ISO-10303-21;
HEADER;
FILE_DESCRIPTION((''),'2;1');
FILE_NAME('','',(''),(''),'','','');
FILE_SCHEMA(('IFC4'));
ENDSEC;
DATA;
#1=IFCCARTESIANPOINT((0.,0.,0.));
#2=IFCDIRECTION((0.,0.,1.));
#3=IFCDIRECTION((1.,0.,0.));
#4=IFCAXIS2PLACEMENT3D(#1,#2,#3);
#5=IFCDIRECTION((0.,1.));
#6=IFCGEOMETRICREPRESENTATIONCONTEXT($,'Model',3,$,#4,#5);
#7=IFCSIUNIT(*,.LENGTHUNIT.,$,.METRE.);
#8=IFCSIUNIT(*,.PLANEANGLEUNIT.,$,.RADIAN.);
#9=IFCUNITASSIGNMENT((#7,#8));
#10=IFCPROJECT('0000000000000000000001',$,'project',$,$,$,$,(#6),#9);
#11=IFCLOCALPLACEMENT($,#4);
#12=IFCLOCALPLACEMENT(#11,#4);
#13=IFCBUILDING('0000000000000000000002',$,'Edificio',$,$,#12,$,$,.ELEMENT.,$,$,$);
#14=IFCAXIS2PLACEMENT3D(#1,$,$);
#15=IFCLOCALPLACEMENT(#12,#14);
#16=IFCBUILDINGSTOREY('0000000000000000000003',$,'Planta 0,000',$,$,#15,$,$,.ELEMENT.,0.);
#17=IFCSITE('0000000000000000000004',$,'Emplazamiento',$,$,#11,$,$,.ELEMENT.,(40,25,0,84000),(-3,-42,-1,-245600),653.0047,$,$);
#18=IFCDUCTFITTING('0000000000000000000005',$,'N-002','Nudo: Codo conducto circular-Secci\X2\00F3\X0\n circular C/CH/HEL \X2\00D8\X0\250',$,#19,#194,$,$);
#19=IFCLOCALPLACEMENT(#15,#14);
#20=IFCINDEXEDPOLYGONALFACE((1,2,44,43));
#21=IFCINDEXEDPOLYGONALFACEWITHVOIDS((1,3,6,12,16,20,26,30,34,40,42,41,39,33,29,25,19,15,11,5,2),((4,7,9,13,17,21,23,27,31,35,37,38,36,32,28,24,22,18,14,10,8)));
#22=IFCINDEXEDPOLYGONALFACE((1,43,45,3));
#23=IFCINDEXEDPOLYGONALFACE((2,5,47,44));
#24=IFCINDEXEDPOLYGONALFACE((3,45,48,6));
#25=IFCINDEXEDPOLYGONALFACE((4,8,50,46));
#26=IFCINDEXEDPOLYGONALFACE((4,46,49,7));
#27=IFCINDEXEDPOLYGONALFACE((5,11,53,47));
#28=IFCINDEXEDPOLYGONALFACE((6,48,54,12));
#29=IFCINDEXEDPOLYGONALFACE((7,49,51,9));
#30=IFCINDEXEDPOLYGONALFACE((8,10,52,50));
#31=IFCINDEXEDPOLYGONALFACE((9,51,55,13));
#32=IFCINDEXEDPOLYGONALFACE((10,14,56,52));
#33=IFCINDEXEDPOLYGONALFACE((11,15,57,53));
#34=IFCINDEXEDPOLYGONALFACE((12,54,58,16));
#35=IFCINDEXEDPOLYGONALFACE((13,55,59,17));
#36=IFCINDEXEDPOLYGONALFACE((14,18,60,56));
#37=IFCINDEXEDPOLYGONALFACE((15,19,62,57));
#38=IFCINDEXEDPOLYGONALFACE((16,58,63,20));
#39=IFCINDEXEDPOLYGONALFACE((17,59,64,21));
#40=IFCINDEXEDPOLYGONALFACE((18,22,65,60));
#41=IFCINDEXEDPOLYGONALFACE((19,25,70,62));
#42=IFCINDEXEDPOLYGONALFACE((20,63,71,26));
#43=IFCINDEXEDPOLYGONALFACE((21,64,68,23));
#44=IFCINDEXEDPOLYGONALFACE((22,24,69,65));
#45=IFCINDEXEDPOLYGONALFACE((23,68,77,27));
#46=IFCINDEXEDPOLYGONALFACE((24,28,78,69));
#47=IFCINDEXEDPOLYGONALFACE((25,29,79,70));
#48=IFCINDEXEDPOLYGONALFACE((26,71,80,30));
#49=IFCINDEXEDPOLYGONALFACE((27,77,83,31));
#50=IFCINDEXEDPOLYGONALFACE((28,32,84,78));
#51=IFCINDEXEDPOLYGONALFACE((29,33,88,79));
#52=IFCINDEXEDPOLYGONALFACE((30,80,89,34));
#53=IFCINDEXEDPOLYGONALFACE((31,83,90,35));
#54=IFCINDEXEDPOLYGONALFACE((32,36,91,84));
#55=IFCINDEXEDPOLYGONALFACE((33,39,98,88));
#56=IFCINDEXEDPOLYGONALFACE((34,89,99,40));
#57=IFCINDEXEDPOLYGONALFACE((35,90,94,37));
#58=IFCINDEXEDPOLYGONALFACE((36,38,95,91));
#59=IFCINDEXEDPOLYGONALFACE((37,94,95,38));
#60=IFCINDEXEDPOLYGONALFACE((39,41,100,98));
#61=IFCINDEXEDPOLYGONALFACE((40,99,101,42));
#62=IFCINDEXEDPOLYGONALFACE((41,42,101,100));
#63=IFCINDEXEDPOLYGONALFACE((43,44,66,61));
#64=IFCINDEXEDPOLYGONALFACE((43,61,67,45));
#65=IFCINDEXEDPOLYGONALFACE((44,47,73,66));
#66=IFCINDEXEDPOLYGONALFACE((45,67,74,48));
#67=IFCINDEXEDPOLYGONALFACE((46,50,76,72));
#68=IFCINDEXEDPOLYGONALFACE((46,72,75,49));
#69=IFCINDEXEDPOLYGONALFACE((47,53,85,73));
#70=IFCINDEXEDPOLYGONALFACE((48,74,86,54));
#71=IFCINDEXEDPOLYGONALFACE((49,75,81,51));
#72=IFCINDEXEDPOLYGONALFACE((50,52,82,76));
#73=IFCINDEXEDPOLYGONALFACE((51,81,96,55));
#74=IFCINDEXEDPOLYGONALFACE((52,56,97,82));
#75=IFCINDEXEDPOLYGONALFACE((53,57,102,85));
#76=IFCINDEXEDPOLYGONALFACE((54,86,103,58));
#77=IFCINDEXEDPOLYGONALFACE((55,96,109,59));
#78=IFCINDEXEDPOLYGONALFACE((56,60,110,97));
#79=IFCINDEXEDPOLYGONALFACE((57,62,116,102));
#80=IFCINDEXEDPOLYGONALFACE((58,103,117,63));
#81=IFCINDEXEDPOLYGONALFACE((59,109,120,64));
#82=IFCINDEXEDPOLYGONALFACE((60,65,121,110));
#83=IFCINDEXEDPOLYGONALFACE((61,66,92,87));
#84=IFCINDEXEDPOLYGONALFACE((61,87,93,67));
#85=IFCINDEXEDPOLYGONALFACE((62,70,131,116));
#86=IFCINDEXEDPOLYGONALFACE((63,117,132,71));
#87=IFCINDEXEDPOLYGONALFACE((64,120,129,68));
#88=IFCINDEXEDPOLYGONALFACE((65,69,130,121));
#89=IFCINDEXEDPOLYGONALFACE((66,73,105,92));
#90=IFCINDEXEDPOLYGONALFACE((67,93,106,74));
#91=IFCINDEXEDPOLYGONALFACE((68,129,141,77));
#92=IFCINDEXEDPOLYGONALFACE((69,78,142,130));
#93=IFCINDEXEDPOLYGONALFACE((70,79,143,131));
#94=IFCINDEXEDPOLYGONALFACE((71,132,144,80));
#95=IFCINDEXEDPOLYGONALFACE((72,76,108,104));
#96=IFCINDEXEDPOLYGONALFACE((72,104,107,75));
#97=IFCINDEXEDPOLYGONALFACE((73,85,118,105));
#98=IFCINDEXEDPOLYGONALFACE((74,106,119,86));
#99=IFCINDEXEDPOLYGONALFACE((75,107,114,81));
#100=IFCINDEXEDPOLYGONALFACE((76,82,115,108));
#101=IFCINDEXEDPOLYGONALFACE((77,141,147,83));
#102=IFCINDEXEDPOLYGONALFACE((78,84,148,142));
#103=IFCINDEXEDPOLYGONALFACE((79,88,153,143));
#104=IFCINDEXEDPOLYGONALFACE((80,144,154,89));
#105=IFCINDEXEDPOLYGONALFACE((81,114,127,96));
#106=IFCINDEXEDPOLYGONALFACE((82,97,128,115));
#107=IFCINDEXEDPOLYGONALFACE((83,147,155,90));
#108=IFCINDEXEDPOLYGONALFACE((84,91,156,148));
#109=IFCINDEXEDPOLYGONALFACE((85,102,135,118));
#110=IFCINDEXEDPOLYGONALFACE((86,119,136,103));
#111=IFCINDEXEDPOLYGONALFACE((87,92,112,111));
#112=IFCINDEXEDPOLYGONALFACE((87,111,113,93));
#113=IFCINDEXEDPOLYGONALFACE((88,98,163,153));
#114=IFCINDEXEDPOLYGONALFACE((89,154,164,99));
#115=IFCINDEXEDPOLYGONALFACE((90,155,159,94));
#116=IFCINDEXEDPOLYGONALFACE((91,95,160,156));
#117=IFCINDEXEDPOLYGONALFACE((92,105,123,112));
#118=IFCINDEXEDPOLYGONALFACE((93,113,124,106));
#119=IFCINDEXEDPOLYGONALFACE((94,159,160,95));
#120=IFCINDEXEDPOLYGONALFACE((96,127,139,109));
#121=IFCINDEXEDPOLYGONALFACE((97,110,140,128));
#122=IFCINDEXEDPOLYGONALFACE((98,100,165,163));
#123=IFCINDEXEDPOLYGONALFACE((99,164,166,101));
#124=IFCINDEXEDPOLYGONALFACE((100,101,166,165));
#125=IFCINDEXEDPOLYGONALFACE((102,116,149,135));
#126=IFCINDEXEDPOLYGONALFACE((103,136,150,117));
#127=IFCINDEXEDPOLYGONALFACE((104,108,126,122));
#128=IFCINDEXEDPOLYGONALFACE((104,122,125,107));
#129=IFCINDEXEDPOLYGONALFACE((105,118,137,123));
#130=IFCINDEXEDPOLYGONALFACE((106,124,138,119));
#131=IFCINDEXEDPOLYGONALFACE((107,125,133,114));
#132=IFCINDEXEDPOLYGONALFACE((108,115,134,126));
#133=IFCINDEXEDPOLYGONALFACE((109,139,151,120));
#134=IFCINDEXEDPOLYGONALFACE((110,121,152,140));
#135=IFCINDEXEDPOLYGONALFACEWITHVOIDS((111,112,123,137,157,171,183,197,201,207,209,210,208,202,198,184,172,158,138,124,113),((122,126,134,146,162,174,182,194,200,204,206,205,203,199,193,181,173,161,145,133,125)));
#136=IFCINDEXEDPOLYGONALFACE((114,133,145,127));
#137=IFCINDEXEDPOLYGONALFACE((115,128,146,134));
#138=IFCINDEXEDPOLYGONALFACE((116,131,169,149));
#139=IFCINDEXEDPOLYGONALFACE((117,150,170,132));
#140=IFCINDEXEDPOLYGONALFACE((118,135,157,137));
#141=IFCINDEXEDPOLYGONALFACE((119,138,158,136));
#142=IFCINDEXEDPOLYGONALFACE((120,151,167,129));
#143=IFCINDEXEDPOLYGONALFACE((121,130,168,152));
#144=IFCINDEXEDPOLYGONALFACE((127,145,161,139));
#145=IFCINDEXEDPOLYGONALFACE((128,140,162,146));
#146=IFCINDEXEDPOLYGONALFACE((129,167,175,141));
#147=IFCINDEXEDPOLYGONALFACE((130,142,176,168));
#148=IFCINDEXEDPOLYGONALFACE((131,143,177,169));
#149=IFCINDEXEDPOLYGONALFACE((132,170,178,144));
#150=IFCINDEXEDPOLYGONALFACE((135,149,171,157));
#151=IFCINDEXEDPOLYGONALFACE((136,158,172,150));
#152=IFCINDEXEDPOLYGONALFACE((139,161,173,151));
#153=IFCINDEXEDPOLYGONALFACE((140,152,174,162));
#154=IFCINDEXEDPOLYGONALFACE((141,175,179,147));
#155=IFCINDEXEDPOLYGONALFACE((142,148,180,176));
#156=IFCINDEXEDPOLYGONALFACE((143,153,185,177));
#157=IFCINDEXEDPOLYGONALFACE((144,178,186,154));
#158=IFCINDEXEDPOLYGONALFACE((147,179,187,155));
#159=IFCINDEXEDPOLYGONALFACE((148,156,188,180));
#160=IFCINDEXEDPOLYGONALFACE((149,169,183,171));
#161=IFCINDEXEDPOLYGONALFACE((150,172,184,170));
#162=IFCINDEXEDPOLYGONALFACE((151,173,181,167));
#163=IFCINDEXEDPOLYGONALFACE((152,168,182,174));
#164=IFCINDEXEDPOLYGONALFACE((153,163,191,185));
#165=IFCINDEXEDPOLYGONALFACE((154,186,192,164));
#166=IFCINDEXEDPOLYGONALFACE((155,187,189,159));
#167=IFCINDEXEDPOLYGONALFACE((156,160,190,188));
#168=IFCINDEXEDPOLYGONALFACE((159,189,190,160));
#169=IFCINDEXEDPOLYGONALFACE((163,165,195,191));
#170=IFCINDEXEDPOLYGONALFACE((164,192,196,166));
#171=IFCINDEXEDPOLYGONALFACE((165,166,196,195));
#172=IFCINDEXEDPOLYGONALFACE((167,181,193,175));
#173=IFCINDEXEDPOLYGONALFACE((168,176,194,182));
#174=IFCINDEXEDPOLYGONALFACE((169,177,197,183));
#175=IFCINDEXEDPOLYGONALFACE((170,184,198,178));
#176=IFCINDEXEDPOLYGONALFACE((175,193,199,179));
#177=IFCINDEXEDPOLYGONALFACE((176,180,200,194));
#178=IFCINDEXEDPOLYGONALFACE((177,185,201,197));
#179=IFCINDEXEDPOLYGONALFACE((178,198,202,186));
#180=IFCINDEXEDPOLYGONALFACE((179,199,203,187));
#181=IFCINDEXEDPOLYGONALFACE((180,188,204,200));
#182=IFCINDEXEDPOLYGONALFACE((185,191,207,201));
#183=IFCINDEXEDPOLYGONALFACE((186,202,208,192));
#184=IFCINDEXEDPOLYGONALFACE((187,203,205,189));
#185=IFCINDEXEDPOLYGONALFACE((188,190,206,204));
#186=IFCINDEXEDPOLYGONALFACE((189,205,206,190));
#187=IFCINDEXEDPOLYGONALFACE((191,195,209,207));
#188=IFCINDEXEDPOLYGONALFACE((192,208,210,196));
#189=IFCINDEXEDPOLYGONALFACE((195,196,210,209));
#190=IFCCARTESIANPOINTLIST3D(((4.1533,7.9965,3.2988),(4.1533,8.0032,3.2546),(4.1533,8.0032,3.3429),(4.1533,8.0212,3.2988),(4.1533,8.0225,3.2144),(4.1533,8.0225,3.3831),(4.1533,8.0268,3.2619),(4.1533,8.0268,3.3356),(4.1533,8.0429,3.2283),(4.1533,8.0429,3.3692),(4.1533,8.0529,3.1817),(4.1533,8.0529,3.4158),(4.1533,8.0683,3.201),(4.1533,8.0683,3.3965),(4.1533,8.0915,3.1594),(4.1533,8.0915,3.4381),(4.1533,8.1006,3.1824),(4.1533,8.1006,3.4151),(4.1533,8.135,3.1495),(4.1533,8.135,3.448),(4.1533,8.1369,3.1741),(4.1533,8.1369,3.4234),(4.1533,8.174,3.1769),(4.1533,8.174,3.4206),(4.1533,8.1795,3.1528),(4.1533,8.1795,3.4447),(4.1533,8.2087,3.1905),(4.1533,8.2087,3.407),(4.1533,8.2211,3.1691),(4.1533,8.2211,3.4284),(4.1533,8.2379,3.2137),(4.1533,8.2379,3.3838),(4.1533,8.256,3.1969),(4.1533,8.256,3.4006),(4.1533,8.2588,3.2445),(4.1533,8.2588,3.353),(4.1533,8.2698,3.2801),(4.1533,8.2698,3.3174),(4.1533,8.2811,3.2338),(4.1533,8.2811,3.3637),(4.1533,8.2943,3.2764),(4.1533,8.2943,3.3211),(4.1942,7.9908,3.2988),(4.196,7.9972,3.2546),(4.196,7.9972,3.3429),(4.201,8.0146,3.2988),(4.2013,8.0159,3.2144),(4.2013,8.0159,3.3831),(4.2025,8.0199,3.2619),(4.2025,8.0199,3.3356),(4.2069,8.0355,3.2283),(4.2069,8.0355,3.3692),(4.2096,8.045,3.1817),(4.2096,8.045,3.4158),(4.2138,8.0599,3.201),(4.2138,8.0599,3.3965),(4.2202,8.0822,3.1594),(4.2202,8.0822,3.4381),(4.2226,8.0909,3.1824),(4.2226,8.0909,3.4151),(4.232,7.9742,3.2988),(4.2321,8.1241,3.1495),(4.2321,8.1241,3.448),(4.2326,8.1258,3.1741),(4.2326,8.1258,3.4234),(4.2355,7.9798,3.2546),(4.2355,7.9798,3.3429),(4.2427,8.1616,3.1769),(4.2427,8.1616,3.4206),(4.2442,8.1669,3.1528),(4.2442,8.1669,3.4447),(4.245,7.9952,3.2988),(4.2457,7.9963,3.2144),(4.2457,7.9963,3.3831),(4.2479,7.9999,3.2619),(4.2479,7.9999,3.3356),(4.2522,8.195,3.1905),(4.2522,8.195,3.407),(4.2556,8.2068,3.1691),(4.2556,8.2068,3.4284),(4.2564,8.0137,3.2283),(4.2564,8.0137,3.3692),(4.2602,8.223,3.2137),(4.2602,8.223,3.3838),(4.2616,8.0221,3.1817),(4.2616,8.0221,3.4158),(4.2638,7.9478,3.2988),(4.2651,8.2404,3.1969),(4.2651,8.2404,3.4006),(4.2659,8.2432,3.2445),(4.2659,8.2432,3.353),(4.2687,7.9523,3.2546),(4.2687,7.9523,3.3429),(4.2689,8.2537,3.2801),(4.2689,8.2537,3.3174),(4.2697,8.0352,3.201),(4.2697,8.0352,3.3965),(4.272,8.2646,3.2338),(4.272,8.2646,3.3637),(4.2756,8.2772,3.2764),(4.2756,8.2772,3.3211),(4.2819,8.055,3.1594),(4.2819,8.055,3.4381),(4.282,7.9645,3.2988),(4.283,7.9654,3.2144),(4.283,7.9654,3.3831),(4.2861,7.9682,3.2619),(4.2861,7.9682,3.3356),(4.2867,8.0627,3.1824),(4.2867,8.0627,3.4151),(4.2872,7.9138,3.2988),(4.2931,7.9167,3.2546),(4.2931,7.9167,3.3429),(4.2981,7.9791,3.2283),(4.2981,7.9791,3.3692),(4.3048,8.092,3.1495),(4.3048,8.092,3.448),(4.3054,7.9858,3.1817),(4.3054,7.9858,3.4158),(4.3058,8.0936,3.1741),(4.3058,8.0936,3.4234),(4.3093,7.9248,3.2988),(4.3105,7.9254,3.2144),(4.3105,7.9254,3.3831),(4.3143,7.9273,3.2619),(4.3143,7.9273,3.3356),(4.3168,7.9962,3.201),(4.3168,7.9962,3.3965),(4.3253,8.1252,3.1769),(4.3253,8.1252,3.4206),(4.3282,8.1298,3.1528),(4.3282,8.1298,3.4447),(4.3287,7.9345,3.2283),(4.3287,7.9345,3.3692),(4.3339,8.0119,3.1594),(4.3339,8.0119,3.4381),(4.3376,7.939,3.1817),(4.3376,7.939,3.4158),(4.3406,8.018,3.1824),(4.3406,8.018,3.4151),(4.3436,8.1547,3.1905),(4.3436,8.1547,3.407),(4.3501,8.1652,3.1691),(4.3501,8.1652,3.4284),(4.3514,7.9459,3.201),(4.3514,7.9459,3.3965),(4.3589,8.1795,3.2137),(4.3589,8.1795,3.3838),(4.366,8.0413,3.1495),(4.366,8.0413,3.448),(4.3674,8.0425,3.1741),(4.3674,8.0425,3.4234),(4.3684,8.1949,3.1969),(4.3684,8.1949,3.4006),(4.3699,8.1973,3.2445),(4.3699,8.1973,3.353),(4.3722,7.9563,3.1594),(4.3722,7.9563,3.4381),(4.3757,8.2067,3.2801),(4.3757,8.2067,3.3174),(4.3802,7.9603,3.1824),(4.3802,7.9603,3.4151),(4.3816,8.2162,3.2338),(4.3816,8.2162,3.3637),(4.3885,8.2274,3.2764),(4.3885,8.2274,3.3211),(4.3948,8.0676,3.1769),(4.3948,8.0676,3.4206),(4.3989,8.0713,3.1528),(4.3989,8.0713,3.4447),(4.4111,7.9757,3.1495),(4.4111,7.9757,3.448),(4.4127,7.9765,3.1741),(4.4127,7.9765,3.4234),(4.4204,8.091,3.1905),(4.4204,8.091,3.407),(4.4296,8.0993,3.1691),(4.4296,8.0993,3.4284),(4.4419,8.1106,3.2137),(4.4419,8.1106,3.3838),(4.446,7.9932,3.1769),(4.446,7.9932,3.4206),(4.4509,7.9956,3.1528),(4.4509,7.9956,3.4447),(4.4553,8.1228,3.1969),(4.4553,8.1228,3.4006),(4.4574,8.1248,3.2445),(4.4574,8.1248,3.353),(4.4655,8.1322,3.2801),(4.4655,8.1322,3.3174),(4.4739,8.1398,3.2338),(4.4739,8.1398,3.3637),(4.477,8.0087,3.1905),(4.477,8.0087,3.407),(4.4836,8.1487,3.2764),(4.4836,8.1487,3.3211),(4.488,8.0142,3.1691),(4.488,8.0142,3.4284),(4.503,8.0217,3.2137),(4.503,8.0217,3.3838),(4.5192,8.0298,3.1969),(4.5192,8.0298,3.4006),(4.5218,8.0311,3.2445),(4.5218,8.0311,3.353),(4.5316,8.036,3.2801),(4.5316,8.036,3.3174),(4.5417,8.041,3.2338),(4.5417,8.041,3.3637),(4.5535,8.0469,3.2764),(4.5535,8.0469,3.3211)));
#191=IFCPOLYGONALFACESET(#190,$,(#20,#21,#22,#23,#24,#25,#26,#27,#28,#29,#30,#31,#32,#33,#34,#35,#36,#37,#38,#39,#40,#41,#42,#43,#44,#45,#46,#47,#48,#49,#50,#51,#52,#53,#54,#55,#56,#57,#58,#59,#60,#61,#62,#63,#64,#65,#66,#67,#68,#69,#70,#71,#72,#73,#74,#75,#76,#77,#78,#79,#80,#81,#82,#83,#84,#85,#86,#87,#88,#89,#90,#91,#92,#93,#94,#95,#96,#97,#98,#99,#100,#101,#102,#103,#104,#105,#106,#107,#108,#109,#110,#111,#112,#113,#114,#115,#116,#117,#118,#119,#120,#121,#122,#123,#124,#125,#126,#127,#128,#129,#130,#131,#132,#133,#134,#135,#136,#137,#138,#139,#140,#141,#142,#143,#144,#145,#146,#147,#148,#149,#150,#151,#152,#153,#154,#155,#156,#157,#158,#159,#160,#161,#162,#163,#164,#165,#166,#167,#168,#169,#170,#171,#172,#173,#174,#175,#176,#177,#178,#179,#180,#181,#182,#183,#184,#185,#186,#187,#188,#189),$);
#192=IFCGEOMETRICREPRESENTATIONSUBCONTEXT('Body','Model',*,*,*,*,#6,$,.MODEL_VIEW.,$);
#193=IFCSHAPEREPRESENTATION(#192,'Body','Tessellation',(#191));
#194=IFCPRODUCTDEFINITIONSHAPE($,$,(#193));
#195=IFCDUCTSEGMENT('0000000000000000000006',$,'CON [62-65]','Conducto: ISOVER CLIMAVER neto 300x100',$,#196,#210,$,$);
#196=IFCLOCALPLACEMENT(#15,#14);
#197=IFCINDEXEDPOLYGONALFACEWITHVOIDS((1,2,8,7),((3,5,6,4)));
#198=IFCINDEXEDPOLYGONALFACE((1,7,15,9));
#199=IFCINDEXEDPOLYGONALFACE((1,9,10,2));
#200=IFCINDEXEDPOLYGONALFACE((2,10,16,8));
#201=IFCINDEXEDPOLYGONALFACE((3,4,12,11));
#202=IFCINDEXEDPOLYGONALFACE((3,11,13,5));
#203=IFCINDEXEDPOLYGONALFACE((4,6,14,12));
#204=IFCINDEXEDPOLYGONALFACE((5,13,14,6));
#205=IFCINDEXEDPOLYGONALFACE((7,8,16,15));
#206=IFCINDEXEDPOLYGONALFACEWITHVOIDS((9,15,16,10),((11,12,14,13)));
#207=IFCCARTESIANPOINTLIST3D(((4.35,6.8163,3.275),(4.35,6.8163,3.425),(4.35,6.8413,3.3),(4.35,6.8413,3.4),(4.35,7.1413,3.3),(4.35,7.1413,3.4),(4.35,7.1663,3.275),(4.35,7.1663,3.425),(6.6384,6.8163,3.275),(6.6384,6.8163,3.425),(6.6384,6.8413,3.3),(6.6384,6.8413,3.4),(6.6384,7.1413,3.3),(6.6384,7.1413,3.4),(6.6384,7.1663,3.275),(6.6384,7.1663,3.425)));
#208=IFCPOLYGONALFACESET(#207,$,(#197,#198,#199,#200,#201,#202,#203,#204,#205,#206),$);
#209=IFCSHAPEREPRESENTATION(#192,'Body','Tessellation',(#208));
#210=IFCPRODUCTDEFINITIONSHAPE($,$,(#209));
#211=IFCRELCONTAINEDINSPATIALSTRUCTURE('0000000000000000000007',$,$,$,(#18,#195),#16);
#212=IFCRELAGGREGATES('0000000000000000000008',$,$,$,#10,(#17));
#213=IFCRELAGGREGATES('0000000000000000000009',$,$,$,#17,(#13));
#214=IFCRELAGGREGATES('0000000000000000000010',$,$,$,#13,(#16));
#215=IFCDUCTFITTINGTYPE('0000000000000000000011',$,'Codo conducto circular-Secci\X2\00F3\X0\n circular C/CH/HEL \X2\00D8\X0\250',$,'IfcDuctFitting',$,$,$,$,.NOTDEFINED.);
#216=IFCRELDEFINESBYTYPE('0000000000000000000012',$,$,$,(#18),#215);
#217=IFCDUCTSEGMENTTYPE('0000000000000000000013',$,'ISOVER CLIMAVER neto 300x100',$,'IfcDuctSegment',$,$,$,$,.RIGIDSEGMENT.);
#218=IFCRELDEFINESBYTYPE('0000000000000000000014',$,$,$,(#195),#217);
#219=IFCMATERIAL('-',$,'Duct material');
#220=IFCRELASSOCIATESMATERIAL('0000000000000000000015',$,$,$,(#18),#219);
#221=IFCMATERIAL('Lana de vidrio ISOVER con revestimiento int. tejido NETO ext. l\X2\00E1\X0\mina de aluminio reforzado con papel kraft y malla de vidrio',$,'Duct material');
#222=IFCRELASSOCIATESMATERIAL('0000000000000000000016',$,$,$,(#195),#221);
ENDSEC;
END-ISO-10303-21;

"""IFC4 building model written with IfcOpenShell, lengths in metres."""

from ifc_helpers import new_model, entity, si_unit, direction, frame, origin, origin_with_axes, origin_2d_with_axis, place, context, subcontext, project, spatial, hollow_rectangle, extrude, source, transform, mapped, material, type_object, element, save


model = new_model("IFC4")

# Units and contexts
model_context = context("Model", 3, world=origin_with_axes(), true_north=direction((0.0, 1.0)))
body_context = subcontext(model_context, "Body", "Model", "MODEL_VIEW")
ifc_project = project(units=[si_unit("LENGTHUNIT", "METRE"), si_unit("PLANEANGLEUNIT", "RADIAN")], contexts=[model_context])

# Site, building, storey
site_placement = place(None, origin_with_axes())
site = spatial("IfcSite", under=ifc_project, at=site_placement, Name="Emplazamiento", CompositionType="ELEMENT", RefLatitude=(40, 25, 0, 84000), RefLongitude=(-3, -42, -1, -245600), RefElevation=653.0047)
building_placement = place(site_placement, origin_with_axes())
building = spatial("IfcBuilding", under=site, at=building_placement, Name="Edificio", CompositionType="ELEMENT")
storey_placement = place(building_placement, origin())
storey = spatial("IfcBuildingStorey", under=building, at=storey_placement, Name="Planta 0,000", CompositionType="ELEMENT", Elevation=0.0)

# Shared definitions
ifc_material_1 = material(Name="-", Category="Duct material")

# Shared definitions
ifc_material_2 = material(Name="Lana de vidrio ISOVER con revestimiento int. tejido NETO ext. lámina de aluminio reforzado con papel kraft y malla de vidrio", Category="Duct material")

# Duct fitting
duct_fitting_type_1 = type_object("IfcDuctFittingType", Name="Codo conducto circular-Sección circular C/CH/HEL Ø250", ApplicableOccurrence="IfcDuctFitting", PredefinedType="NOTDEFINED")
shared_shape_1 = source(origin_with_axes(), body_context, "Body", "SweptSolid", [
    entity("IfcRevolvedAreaSolid", entity("IfcCircleHollowProfileDef", "AREA", None, entity("IfcAxis2Placement2D", entity("IfcCartesianPoint", [0.0, 0.0]), entity("IfcDirection", [1.0, 0.0])), 0.1497, 0.0247), entity("IfcAxis2Placement3D", entity("IfcCartesianPoint", [0.1655, 0.0828, 0.0]), entity("IfcDirection", [-0.894427, -0.447214, 0.0]), entity("IfcDirection", [0.447214, -0.894427, 0.0])), entity("IfcAxis1Placement", entity("IfcCartesianPoint", [0.2994, 0.0, 0.0]), entity("IfcDirection", [0.0, 1.0, 0.0])), 1.107149),
])
duct_fitting_1_placement = place(storey_placement, origin_with_axes())
element("IfcDuctFitting", 1, at=duct_fitting_1_placement, inside=storey, type_object=duct_fitting_type_1, material=ifc_material_1, Name="N-002", Description="Nudo: Codo conducto circular-Sección circular C/CH/HEL Ø250", context=body_context, shape_type="MappedRepresentation", body=[
    mapped(shared_shape_1, transform((4.3383, 8.1462, 3.2988), x_axis=(0.0, -1.0, 0.0), y_axis=(1.0, 0.0, 0.0), z_axis=(0.0, 0.0, 1.0), scale=1.0)),
])

# Duct segment
duct_segment_type_1 = type_object("IfcDuctSegmentType", Name="ISOVER CLIMAVER neto 300x100", ApplicableOccurrence="IfcDuctSegment", PredefinedType="RIGIDSEGMENT")
duct_segment_1_placement = place(storey_placement, origin_with_axes())
element("IfcDuctSegment", 2, at=duct_segment_1_placement, inside=storey, type_object=duct_segment_type_1, material=ifc_material_2, Name="CON [62-65]", Description="Conducto: ISOVER CLIMAVER neto 300x100", context=body_context, shape_type="SweptSolid", body=[
    extrude(hollow_rectangle(XDim=0.35, YDim=0.15, WallThickness=0.025, at=origin_2d_with_axis()), frame((6.6384, 6.9913, 3.35), z_axis=(-1.0, 0.0, 0.0), x_axis=(0.0, -1.0, 0.0)), (0.0, 0.0, 1.0), 2.2884),
])

save(model, "model.ifc")
